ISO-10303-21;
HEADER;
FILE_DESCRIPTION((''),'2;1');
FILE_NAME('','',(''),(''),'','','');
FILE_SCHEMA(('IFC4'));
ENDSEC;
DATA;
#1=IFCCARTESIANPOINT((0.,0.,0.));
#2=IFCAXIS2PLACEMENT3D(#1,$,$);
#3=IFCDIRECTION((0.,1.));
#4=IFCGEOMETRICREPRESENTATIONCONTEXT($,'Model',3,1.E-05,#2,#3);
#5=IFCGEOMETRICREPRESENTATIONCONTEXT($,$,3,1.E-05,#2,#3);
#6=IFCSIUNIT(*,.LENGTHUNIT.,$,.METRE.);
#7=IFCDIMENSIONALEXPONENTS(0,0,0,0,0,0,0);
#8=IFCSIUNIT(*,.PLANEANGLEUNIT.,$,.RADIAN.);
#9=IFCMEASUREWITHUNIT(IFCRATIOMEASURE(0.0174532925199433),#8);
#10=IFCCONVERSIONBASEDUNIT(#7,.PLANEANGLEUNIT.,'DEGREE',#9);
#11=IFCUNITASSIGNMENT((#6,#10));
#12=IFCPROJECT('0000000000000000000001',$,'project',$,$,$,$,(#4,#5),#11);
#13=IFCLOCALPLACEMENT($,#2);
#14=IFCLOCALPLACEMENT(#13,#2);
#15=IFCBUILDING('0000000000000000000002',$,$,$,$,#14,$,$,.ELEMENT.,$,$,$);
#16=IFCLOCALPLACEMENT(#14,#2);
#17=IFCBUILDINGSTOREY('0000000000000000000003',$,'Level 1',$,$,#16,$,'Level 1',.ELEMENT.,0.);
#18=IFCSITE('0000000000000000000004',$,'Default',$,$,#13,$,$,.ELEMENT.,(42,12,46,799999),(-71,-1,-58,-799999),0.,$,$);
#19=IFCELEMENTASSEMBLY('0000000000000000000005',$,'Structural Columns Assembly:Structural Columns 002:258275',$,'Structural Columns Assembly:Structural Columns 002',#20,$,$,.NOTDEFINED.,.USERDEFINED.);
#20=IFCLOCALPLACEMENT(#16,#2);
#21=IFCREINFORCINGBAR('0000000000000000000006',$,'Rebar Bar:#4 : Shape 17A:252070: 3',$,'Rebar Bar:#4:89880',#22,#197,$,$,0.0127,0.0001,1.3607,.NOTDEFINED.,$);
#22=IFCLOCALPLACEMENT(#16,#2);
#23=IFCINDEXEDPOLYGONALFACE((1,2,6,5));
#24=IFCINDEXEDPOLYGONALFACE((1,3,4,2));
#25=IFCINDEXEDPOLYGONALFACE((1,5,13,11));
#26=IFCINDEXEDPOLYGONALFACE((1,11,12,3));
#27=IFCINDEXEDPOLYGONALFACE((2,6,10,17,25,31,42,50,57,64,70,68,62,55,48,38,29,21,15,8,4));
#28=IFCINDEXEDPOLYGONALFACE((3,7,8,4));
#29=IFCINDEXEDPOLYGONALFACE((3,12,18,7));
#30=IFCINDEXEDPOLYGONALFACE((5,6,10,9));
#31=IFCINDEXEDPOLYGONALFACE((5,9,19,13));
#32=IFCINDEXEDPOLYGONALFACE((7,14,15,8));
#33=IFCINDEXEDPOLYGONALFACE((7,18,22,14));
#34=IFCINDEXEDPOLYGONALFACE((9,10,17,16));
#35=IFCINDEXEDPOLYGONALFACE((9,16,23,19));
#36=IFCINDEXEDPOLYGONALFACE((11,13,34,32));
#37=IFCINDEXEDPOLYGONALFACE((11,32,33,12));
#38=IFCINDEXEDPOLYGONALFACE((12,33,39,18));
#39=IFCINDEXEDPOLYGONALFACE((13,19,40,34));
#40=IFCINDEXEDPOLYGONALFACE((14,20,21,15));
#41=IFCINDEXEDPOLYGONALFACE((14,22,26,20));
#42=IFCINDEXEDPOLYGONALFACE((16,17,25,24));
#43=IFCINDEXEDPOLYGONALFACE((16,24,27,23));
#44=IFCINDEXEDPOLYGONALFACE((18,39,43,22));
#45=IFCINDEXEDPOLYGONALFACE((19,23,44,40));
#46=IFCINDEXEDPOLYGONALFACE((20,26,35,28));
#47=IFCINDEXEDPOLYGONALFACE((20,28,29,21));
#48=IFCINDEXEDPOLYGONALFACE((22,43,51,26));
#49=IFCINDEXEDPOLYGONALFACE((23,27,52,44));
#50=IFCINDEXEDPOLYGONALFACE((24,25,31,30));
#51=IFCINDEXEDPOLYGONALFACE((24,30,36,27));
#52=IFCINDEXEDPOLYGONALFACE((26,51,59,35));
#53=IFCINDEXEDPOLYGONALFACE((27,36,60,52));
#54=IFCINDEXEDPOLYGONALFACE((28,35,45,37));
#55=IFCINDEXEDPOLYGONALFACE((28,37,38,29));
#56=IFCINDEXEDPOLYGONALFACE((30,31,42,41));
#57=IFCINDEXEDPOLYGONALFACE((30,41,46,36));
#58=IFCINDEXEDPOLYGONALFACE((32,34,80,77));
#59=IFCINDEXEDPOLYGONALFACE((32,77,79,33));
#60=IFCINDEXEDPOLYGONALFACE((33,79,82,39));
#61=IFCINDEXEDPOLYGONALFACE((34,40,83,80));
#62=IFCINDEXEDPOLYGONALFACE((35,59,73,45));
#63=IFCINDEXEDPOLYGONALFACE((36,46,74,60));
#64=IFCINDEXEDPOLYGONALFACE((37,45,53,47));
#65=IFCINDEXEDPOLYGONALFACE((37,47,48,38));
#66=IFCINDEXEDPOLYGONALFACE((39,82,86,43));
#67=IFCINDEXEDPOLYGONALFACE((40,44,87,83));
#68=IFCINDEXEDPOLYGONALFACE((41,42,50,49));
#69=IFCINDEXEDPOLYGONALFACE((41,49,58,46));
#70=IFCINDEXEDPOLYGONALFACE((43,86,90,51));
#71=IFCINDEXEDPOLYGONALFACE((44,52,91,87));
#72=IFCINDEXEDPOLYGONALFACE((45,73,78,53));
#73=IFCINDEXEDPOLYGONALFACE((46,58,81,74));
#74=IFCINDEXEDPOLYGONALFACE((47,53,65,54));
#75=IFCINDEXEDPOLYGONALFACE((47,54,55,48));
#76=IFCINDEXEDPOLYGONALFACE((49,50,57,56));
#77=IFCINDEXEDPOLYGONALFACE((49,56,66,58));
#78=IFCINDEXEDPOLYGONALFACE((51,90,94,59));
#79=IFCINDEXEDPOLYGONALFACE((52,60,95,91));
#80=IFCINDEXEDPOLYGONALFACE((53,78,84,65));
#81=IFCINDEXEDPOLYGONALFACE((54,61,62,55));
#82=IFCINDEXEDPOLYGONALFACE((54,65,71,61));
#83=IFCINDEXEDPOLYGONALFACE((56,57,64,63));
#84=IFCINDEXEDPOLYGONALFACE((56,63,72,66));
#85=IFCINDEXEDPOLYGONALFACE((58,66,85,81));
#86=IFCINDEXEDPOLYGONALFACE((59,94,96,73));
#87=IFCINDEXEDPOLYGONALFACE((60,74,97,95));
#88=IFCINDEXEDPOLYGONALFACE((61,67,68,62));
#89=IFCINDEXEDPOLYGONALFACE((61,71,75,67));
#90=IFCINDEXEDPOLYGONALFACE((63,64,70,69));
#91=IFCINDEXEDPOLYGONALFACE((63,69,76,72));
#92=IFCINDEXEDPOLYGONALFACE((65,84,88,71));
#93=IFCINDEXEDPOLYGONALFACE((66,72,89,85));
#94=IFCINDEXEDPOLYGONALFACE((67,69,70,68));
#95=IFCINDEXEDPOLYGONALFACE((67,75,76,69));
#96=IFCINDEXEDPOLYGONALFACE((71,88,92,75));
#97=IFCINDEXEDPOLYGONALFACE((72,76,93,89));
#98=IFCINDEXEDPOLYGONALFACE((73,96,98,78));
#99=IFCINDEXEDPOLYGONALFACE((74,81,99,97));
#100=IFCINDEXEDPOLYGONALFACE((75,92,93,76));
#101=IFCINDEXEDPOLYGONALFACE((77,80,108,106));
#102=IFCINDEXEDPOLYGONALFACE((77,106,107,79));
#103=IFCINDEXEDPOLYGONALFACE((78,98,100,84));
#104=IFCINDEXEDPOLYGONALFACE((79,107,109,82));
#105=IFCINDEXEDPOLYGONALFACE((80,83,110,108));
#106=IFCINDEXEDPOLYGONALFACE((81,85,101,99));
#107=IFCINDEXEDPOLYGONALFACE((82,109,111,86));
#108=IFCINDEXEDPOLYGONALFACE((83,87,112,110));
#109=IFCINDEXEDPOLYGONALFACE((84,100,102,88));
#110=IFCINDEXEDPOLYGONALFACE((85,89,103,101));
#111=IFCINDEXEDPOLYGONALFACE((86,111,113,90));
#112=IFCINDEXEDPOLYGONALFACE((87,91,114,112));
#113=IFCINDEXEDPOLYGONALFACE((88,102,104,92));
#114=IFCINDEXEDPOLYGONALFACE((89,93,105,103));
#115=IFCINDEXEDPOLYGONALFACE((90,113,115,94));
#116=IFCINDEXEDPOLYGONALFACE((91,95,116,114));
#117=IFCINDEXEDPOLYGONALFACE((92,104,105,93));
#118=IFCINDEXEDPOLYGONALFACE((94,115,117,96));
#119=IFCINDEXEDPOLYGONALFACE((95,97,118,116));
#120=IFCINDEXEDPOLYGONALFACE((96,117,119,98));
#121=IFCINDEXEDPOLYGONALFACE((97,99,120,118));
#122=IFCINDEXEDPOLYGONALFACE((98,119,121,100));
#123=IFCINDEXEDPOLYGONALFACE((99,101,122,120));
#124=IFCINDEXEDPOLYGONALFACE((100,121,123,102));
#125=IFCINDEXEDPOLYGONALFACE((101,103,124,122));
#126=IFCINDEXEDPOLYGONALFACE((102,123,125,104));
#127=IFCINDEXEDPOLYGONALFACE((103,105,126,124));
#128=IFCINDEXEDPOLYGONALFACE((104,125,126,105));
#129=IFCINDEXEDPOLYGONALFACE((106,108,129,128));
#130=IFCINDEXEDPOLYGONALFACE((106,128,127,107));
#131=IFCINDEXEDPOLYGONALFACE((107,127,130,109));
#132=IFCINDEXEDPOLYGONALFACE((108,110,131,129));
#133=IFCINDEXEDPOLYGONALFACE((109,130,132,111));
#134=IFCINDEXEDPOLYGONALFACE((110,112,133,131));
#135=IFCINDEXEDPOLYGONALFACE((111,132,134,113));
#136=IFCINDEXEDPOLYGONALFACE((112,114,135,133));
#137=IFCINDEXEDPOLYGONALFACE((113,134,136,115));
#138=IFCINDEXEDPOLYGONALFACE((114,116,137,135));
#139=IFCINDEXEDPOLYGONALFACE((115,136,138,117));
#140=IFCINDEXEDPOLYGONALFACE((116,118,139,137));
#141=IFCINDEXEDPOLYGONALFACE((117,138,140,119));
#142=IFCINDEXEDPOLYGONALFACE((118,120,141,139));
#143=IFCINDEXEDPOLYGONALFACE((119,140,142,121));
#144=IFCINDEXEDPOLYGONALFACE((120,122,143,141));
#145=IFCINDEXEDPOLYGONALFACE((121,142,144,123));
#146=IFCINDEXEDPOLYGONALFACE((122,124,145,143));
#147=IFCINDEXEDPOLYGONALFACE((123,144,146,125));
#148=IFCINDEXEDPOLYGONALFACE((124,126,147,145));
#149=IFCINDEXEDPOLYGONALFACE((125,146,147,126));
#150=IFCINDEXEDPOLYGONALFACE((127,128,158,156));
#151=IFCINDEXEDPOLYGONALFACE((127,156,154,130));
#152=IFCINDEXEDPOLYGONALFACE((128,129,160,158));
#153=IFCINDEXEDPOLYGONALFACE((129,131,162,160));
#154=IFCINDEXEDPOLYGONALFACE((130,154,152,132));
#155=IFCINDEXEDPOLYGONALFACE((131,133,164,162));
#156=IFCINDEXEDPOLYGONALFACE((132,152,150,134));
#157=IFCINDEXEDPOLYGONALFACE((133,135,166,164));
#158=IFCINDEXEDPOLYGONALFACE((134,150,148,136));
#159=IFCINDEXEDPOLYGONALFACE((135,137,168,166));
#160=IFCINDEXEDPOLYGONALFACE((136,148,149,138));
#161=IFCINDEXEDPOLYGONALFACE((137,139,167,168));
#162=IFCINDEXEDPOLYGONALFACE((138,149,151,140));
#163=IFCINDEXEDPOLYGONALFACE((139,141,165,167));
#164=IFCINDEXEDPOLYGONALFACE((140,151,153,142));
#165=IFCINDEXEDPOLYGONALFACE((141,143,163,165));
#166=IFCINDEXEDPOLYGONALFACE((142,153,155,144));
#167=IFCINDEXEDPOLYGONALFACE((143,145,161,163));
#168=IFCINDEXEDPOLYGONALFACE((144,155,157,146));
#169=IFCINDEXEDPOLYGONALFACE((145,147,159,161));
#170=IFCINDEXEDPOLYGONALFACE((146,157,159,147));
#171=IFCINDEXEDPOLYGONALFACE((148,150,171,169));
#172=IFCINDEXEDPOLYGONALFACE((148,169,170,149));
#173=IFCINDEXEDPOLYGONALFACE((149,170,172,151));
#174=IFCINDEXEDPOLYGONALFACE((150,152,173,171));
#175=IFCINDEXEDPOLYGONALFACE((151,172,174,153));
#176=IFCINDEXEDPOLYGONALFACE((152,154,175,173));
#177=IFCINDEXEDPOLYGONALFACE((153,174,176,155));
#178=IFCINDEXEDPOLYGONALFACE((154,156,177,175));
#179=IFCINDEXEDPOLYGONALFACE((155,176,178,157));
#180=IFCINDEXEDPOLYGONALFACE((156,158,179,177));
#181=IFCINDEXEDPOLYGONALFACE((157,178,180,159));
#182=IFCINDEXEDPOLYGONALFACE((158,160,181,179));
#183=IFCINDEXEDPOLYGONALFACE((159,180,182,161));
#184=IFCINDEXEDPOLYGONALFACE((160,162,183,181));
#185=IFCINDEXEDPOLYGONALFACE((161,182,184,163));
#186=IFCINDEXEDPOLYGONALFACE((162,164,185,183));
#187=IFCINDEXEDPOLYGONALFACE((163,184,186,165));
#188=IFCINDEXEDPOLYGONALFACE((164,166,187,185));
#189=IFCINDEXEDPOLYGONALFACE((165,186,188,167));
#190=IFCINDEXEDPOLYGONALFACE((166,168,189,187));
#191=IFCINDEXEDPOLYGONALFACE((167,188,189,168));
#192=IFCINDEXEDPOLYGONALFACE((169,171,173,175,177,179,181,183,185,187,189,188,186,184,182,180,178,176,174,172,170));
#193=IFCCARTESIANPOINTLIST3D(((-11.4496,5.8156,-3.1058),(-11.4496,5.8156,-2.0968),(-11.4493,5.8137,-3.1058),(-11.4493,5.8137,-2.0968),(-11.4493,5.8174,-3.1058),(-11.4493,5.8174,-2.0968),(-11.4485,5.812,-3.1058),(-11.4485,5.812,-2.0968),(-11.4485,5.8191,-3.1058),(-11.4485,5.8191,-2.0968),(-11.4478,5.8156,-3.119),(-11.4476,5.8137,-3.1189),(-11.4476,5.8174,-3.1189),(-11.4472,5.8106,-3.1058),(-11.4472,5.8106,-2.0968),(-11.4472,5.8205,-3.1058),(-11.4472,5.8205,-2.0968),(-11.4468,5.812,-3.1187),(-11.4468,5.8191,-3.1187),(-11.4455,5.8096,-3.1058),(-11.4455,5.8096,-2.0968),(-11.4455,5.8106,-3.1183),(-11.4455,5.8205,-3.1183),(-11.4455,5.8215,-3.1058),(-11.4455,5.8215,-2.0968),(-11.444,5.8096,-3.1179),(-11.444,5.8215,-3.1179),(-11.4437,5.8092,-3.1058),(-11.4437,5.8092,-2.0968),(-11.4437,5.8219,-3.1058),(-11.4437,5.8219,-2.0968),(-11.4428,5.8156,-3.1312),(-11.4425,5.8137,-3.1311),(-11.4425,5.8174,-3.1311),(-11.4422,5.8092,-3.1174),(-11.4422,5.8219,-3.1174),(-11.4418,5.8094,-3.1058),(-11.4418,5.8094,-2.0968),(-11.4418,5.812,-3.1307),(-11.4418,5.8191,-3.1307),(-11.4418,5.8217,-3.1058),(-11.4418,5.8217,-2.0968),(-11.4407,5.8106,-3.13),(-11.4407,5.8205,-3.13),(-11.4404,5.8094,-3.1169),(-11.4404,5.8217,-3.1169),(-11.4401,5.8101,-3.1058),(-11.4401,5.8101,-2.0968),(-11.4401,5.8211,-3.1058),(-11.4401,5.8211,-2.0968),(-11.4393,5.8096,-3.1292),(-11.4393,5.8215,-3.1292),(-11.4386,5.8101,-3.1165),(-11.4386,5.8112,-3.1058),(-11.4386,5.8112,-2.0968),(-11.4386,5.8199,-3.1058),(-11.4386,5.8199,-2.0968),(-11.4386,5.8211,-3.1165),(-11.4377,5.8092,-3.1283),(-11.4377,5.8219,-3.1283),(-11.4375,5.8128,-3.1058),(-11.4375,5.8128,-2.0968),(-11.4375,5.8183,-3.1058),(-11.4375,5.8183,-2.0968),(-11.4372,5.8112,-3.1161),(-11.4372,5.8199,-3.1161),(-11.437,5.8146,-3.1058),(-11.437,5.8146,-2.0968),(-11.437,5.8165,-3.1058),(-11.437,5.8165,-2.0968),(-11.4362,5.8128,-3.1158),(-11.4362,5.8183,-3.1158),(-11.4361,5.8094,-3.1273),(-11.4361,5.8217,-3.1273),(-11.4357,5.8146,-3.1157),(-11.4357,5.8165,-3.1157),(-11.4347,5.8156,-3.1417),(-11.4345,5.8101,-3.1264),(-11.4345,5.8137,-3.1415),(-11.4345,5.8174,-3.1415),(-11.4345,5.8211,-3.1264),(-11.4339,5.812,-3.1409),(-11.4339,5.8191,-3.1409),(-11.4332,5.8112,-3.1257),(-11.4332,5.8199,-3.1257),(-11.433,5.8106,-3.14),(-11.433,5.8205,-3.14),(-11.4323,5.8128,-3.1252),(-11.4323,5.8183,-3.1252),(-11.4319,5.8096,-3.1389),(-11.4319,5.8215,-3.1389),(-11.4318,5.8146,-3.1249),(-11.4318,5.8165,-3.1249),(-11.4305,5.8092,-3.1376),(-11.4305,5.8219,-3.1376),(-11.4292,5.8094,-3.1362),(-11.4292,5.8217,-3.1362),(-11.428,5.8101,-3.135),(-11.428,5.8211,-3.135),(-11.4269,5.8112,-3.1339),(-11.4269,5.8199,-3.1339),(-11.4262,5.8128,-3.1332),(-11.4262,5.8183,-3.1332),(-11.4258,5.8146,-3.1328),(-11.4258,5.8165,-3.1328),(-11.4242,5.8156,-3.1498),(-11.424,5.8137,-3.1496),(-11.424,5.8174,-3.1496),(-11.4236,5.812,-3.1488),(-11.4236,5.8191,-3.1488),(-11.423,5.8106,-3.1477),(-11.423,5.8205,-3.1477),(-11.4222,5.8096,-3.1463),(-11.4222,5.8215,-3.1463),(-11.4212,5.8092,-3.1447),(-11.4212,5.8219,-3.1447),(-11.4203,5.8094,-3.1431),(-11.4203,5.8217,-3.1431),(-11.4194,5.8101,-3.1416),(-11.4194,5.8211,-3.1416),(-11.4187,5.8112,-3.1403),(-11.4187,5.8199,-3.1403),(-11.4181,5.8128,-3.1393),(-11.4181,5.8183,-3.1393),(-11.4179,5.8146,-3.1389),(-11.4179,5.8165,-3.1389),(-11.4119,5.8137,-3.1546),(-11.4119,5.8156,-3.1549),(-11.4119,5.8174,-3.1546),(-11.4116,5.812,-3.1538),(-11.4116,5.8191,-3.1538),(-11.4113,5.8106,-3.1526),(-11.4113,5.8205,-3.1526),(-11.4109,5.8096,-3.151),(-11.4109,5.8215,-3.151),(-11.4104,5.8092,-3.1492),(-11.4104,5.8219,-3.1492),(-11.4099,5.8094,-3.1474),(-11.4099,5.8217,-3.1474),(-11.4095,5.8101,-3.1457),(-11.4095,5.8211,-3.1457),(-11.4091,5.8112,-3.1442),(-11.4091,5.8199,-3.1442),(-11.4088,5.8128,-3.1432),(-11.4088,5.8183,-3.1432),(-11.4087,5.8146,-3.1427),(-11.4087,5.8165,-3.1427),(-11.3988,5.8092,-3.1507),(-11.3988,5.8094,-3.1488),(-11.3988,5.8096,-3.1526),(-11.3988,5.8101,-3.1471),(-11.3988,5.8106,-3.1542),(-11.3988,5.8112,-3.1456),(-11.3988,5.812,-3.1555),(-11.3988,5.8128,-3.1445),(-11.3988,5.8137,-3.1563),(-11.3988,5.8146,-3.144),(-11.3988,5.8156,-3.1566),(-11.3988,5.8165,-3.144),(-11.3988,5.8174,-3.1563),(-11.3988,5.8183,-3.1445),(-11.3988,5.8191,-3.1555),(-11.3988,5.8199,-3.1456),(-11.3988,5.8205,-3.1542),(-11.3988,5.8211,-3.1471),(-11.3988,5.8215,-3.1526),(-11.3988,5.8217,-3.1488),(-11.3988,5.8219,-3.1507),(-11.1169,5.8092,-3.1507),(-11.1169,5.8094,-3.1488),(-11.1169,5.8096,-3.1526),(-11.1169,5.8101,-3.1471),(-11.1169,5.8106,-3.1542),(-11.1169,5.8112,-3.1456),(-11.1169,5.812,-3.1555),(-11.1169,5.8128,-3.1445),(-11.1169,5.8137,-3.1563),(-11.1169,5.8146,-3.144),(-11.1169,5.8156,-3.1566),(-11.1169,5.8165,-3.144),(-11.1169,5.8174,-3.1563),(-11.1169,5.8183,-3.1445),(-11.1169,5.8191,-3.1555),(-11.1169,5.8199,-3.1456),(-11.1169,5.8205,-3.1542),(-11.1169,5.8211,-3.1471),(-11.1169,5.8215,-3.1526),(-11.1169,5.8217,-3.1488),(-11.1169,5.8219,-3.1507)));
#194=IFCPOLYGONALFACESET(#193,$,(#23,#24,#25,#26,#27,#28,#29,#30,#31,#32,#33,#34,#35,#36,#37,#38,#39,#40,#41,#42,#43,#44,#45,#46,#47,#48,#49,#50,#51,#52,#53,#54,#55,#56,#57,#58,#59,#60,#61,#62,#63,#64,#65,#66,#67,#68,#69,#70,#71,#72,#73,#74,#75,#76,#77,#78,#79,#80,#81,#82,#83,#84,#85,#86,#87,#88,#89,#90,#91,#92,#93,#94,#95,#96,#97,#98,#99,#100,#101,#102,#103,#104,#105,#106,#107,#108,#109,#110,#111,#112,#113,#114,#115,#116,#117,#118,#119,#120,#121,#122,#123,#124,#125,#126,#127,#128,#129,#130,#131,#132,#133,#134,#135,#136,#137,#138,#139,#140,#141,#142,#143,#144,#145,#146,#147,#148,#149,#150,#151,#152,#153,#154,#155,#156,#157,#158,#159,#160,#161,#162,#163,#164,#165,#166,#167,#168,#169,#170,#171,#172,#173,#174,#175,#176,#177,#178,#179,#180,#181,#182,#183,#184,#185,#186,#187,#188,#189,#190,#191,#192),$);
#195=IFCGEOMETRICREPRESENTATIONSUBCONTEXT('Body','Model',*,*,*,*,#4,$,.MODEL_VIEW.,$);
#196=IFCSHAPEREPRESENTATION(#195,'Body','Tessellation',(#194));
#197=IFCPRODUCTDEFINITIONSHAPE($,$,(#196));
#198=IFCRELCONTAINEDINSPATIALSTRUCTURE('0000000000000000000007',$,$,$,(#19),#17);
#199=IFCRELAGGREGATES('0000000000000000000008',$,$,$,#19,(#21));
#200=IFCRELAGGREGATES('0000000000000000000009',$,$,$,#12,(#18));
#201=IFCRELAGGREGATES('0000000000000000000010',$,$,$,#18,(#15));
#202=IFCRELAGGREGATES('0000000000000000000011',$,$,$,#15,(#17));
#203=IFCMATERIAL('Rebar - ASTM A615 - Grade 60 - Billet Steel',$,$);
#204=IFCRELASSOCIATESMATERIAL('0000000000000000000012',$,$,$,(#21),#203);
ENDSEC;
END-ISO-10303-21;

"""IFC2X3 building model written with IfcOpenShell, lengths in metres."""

from ifc_helpers import new_model, entity, si_unit, converted_unit, direction, origin, place, context, subcontext, project, spatial, material, element, aggregate, save


model = new_model("IFC2X3")

# Units and contexts
model_context = context("Model", 3, precision=1e-05, world=origin(), true_north=direction((0.0, 1.0)))
context_of_model = context(None, 3, precision=1e-05, world=origin(), true_north=direction((0.0, 1.0)))
body_context = subcontext(model_context, "Body", "Model", "MODEL_VIEW")
ifc_project = project(units=[si_unit("LENGTHUNIT", "METRE"), converted_unit("PLANEANGLEUNIT", "DEGREE", entity("IfcRatioMeasure", 0.0174532925199433), si_unit("PLANEANGLEUNIT", "RADIAN"), dimensions=[0, 0, 0, 0, 0, 0, 0])], contexts=[model_context, context_of_model])

# Site, building, storey
site_placement = place(None, origin())
site = spatial("IfcSite", under=ifc_project, at=site_placement, Name="Default", CompositionType="ELEMENT", RefLatitude=(42, 12, 46, 799999), RefLongitude=(-71, -1, -58, -799999), RefElevation=0.0)
building_placement = place(site_placement, origin())
building = spatial("IfcBuilding", under=site, at=building_placement, CompositionType="ELEMENT")
storey_placement = place(building_placement, origin())
storey = spatial("IfcBuildingStorey", under=building, at=storey_placement, Name="Level 1", LongName="Level 1", CompositionType="ELEMENT", Elevation=0.0)

# Element assembly, reinforcing bar
assembly_1_placement = place(storey_placement, origin())
assembly_1 = element("IfcElementAssembly", 1, at=assembly_1_placement, inside=storey, Name="Structural Columns Assembly:Structural Columns 002:258275", ObjectType="Structural Columns Assembly:Structural Columns 002", AssemblyPlace="NOTDEFINED", PredefinedType="USERDEFINED")
ifc_material_1 = material(Name="Rebar - ASTM A615 - Grade 60 - Billet Steel")
reinforcing_bar_1_placement = place(assembly_1_placement, origin())
reinforcing_bar_1 = element("IfcReinforcingBar", 2, at=reinforcing_bar_1_placement, material=ifc_material_1, Name="Rebar Bar:#4 : Shape 17A:252070: 3", ObjectType="Rebar Bar:#4:89880", BarLength=1.3607, BarRole="NOTDEFINED", CrossSectionArea=0.0001, NominalDiameter=0.0127, context=body_context, shape_type="AdvancedSweptSolid", body=[
    entity("IfcSweptDiskSolid", entity("IfcCompositeCurve", [entity("IfcCompositeCurveSegment", "CONTINUOUS", True, entity("IfcPolyline", [entity("IfcCartesianPoint", [-11.4432, 5.8156, -2.0968]), entity("IfcCartesianPoint", [-11.4432, 5.8156, -3.1058])])), entity("IfcCompositeCurveSegment", "CONTINUOUS", True, entity("IfcTrimmedCurve", entity("IfcCircle", entity("IfcAxis2Placement3D", entity("IfcCartesianPoint", [-11.3988, 5.8156, -3.1058]), entity("IfcDirection", [0.0, -1.0, 0.0]), entity("IfcDirection", [0.0, 0.0, -1.0])), 0.0445), [entity("IfcParameterValue", 270.0)], [entity("IfcParameterValue", 360.0)], True, "PARAMETER")), entity("IfcCompositeCurveSegment", "CONTINUOUS", True, entity("IfcPolyline", [entity("IfcCartesianPoint", [-11.3988, 5.8156, -3.1503]), entity("IfcCartesianPoint", [-11.1169, 5.8156, -3.1503])]))], False), 0.0063, None, 0.0, 92.0),
])
aggregate(assembly_1, [reinforcing_bar_1])

save(model, "model.ifc")
